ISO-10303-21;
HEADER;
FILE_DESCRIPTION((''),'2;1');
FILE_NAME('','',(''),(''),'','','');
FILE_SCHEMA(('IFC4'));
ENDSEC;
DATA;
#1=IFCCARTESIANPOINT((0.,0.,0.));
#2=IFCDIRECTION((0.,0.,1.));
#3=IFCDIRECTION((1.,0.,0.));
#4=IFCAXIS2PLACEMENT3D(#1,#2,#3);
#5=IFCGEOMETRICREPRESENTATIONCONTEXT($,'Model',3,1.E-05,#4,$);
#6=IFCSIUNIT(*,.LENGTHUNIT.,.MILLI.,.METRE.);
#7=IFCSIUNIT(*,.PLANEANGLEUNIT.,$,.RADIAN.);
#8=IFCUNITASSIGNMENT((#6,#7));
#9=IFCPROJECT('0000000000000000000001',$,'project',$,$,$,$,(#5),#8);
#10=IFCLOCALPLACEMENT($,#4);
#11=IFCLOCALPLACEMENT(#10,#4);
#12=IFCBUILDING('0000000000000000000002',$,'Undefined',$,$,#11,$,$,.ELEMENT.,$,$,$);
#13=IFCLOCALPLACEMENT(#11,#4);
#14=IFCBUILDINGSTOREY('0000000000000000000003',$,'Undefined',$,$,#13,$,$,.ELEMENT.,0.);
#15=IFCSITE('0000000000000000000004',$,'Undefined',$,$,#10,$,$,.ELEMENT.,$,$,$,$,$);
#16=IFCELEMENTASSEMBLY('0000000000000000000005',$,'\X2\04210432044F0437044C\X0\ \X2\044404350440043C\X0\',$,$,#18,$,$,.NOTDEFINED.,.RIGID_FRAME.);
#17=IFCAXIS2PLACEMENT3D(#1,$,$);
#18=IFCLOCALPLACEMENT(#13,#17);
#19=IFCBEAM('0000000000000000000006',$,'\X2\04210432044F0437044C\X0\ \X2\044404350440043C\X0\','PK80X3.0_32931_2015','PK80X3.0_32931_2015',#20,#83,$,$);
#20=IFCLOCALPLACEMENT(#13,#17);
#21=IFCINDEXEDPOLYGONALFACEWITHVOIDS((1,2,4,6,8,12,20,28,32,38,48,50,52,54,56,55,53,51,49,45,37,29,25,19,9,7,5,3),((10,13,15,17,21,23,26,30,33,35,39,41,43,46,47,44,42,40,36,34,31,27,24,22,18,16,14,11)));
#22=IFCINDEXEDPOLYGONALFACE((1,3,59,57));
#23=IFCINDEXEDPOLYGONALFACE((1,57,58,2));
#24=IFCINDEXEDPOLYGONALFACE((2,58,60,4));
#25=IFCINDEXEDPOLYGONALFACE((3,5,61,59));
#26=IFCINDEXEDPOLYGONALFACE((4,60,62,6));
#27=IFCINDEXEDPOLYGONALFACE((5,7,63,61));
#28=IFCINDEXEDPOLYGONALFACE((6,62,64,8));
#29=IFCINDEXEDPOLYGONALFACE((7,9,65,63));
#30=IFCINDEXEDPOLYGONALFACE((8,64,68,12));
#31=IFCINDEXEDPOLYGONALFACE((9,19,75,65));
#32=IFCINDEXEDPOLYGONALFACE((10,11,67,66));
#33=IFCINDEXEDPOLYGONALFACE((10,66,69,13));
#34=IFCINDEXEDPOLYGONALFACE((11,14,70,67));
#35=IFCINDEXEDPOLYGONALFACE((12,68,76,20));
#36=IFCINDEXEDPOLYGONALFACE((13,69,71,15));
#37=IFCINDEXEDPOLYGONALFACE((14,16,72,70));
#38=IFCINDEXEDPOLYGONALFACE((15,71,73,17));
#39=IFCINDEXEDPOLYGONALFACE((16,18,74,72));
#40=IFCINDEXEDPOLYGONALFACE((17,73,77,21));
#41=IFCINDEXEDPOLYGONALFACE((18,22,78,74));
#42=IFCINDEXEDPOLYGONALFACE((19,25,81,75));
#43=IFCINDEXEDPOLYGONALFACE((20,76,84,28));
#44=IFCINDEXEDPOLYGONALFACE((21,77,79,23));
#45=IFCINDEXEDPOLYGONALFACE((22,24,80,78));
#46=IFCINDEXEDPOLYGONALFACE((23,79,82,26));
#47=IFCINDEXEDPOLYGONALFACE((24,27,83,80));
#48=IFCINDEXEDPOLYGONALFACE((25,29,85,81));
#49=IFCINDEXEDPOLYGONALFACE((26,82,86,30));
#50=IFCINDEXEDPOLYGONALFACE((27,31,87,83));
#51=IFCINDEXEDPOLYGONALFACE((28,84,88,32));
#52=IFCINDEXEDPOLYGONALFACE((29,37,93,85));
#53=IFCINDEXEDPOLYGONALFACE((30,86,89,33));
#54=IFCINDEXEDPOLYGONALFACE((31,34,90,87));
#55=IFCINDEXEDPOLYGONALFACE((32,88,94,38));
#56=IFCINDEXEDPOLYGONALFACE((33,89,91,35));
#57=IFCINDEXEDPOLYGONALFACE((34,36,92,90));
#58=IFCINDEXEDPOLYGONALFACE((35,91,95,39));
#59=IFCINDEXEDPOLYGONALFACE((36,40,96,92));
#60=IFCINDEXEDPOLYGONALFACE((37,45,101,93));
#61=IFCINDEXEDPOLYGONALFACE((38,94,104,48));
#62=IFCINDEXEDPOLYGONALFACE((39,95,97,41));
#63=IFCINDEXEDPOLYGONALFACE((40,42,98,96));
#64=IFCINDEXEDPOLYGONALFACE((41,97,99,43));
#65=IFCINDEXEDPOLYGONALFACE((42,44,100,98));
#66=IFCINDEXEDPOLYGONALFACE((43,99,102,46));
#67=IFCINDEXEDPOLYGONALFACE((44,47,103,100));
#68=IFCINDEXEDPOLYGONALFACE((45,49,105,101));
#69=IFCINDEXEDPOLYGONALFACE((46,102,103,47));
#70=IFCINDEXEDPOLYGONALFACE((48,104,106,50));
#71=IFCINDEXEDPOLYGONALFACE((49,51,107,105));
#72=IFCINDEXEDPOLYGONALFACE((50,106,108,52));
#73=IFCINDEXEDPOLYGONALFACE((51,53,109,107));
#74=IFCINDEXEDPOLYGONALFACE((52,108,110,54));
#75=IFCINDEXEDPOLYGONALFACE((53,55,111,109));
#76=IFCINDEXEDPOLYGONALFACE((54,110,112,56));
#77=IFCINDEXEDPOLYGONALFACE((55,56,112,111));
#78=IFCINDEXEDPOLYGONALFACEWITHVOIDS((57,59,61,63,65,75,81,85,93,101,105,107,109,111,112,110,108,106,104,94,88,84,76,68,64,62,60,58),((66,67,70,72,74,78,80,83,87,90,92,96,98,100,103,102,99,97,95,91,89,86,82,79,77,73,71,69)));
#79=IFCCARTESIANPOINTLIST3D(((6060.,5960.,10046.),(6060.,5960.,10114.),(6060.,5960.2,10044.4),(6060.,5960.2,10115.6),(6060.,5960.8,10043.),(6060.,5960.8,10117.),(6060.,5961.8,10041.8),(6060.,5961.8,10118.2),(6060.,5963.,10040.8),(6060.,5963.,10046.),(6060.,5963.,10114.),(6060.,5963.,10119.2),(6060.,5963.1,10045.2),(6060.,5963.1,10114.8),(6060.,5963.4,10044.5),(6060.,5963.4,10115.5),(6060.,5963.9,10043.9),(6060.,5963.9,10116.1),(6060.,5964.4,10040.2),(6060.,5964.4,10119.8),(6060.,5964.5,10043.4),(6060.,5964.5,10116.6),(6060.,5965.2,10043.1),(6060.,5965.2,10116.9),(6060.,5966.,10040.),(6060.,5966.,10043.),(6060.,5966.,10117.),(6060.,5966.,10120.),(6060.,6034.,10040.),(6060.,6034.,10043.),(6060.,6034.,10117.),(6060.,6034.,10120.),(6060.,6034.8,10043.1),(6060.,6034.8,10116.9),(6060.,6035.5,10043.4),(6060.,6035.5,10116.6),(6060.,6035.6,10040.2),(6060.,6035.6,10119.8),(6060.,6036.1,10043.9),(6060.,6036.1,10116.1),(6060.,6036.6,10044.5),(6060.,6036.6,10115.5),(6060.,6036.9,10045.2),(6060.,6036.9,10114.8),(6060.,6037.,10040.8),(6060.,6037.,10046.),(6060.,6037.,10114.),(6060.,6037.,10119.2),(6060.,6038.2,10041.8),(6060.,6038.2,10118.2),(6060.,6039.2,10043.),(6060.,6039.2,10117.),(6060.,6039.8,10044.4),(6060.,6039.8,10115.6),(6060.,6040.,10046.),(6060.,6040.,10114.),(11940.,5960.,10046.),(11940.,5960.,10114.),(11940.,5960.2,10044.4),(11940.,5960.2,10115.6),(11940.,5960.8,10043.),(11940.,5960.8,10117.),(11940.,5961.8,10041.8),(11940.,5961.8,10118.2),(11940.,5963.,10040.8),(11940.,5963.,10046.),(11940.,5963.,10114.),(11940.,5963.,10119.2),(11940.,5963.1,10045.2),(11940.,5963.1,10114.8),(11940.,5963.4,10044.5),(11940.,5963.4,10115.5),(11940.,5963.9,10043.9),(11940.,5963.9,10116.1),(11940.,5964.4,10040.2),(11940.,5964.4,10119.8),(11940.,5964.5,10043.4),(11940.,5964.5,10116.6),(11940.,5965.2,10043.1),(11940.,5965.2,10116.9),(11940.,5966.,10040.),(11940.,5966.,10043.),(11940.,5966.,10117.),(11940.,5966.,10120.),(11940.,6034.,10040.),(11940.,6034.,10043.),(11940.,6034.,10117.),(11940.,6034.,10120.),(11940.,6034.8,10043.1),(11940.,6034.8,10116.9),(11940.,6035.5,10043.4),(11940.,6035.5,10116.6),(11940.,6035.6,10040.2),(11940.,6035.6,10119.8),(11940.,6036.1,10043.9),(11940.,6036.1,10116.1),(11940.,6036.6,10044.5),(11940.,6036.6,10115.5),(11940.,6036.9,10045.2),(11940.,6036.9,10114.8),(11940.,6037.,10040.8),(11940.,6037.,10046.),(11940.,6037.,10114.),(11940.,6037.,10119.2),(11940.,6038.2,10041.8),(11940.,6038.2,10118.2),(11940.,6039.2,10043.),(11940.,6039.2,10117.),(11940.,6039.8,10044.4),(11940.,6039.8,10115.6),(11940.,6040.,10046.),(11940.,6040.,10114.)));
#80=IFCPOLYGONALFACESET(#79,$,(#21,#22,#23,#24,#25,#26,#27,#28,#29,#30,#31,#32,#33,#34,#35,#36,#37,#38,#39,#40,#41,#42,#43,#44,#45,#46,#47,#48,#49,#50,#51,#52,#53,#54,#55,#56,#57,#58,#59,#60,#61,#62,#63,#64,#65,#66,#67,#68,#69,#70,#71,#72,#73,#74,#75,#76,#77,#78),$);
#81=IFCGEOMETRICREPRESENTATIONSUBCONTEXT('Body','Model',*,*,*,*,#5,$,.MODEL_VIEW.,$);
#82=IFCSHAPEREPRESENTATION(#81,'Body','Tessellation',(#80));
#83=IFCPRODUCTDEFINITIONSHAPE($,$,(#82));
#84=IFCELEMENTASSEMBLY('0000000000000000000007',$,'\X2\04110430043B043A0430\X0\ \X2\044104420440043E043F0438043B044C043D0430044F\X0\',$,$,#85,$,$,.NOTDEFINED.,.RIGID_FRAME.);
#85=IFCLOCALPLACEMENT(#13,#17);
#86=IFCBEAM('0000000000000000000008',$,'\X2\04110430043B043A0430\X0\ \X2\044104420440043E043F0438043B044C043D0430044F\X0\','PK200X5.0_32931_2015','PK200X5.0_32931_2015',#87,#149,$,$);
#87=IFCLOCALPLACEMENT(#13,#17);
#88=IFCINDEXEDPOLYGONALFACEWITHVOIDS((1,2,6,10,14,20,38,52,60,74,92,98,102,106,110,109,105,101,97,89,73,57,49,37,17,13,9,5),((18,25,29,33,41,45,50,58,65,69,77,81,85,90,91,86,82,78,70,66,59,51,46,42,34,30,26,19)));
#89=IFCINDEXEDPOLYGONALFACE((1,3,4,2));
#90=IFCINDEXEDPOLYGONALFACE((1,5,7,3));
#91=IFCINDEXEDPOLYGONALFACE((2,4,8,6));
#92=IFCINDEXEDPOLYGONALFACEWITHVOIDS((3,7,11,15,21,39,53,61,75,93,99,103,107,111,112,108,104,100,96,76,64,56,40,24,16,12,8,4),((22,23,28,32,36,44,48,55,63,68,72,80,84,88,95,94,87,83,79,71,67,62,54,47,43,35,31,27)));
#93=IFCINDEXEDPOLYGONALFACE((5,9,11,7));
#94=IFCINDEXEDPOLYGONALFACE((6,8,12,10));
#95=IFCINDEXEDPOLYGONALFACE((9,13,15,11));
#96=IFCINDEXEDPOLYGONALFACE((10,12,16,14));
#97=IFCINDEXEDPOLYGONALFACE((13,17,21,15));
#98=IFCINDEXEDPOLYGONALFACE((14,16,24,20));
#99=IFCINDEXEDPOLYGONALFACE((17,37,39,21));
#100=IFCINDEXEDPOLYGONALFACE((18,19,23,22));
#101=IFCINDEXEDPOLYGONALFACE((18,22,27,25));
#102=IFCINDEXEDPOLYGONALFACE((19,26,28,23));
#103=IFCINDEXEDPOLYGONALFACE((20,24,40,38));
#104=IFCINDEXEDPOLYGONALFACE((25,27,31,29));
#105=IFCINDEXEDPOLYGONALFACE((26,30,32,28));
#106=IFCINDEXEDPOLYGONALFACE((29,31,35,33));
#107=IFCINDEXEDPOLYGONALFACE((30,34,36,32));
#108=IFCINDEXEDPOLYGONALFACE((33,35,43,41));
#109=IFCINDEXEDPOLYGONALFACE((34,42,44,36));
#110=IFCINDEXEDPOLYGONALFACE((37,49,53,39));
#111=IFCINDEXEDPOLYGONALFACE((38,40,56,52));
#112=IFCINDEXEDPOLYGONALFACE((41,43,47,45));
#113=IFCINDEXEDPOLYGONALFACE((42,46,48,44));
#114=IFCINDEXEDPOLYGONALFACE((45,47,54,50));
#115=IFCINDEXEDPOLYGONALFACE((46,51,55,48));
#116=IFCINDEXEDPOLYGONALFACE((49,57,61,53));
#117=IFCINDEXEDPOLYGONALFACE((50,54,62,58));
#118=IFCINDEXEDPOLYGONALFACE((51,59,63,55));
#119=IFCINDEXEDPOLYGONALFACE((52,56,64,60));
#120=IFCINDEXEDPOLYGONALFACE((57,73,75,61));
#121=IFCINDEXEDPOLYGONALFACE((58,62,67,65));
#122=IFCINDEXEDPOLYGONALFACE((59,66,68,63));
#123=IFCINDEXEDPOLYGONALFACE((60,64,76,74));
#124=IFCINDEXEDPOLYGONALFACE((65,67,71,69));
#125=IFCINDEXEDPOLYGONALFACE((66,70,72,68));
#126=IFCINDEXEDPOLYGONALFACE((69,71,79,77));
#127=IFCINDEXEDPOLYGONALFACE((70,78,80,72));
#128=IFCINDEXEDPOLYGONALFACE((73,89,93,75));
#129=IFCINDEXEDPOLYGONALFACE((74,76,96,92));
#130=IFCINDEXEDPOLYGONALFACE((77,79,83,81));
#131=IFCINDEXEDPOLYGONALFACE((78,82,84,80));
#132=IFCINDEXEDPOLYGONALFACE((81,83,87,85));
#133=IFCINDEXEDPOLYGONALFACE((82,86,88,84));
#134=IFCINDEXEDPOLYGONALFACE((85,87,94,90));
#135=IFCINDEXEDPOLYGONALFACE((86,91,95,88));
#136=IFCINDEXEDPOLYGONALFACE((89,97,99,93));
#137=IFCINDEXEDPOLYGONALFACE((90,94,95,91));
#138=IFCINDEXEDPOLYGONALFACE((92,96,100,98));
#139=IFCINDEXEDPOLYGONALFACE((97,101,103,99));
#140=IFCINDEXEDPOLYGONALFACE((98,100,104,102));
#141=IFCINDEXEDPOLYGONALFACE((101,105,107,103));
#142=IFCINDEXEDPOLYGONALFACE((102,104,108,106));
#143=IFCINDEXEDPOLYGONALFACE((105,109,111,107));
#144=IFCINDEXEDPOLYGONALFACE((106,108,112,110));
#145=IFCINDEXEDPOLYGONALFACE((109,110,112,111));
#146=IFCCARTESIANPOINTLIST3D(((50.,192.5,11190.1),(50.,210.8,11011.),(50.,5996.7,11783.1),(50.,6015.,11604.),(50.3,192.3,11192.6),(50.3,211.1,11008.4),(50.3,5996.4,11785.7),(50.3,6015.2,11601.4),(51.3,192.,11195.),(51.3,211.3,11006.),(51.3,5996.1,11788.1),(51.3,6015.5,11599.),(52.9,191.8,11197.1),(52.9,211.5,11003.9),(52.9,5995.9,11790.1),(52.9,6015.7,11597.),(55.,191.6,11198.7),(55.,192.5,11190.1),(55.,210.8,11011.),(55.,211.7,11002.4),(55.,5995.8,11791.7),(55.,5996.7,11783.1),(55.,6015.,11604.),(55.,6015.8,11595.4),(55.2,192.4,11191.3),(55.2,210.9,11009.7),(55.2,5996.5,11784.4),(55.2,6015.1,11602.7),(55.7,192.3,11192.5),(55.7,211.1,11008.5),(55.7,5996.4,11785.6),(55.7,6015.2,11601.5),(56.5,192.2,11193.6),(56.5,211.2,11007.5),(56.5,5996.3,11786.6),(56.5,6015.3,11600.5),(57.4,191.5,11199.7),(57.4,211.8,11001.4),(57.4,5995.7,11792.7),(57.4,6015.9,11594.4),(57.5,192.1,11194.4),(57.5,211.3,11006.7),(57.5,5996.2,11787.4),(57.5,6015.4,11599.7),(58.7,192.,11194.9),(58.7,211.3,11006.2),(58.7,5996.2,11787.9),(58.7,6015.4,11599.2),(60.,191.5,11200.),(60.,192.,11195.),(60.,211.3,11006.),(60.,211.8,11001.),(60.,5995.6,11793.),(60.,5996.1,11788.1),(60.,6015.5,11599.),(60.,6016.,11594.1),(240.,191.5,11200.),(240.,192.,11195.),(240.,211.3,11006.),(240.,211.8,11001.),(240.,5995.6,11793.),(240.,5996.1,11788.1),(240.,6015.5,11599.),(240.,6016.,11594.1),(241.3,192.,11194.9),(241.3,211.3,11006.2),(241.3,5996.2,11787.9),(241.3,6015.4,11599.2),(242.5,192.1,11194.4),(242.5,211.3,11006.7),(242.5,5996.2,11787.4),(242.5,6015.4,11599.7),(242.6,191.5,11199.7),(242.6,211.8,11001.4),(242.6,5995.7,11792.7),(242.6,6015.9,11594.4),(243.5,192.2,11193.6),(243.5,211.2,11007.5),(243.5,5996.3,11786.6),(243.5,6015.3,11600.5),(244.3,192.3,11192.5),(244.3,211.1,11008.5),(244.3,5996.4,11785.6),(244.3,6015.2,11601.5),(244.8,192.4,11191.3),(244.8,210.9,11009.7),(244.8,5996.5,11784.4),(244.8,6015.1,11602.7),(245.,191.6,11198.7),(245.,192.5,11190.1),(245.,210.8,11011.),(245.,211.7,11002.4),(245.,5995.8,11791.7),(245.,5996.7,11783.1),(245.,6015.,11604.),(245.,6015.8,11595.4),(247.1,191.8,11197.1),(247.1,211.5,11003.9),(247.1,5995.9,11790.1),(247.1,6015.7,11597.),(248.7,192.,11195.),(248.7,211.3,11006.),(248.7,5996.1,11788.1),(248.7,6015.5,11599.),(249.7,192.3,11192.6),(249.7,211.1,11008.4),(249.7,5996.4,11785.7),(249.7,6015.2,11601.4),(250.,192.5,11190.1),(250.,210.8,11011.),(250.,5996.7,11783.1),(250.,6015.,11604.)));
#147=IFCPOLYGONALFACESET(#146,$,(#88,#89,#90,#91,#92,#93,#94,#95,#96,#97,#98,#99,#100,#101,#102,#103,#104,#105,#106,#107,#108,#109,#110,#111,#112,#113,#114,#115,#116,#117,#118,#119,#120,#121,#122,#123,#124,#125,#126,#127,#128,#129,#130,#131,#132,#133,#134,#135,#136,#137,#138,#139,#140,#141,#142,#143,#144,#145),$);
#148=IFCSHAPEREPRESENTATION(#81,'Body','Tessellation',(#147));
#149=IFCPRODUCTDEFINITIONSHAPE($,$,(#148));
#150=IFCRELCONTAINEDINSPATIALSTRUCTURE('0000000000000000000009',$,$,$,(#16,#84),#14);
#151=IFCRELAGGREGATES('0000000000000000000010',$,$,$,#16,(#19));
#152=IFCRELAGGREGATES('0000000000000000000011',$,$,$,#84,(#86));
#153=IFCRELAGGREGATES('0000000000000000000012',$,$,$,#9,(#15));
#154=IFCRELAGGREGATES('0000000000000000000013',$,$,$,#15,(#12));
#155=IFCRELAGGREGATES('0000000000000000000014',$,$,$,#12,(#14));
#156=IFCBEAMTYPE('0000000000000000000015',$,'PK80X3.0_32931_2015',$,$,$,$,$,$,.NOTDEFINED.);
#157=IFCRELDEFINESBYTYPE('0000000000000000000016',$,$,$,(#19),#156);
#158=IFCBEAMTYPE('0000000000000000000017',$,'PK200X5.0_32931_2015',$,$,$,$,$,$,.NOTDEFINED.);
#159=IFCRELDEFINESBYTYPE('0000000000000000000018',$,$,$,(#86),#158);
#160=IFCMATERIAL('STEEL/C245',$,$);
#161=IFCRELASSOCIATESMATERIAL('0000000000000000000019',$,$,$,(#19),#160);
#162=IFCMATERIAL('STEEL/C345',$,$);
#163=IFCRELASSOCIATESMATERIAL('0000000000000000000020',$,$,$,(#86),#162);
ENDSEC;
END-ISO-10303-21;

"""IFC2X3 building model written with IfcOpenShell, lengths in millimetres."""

from ifc_helpers import new_model, si_unit, frame, origin_with_axes, origin_2d_with_axis, place, context, subcontext, project, spatial, hollow_rectangle, extrude, material, type_object, element, aggregate, save


model = new_model("IFC2X3")

# Units and contexts
model_context = context("Model", 3, precision=1e-05, world=origin_with_axes())
body_context = subcontext(model_context, "Body", "Model", "MODEL_VIEW")
ifc_project = project(units=[si_unit("LENGTHUNIT", "METRE", prefix="MILLI"), si_unit("PLANEANGLEUNIT", "RADIAN")], contexts=[model_context])

# Site, building, storey
site_placement = place(None, origin_with_axes())
site = spatial("IfcSite", under=ifc_project, at=site_placement, Name="Undefined", CompositionType="ELEMENT")
building_placement = place(site_placement, origin_with_axes())
building = spatial("IfcBuilding", under=site, at=building_placement, Name="Undefined", CompositionType="ELEMENT")
storey_placement = place(building_placement, origin_with_axes())
storey = spatial("IfcBuildingStorey", under=building, at=storey_placement, Name="Undefined", CompositionType="ELEMENT", Elevation=0.0)

# Shared definitions
ifc_material_1 = material(Name="STEEL/C245")

# Element assemblies, beams
assembly_1_placement = place(storey_placement, origin_with_axes())
assembly_1 = element("IfcElementAssembly", 1, at=assembly_1_placement, inside=storey, Name="Связь ферм", AssemblyPlace="NOTDEFINED", PredefinedType="RIGID_FRAME")
beam_type_1 = type_object("IfcBeamType", Name="PK80X3.0_32931_2015", PredefinedType="NOTDEFINED")
beam_1_placement = place(assembly_1_placement, frame((6060.0, 6000.0, 10080.0), z_axis=(0.0, 0.0, 1.0), x_axis=(1.0, 0.0, 0.0)))
beam_1 = element("IfcBeam", 2, at=beam_1_placement, type_object=beam_type_1, material=ifc_material_1, Name="Связь ферм", Description="PK80X3.0_32931_2015", ObjectType="PK80X3.0_32931_2015", context=body_context, shape_type="SweptSolid", body=[
    extrude(hollow_rectangle(XDim=80.0, YDim=80.0, WallThickness=3.0, InnerFilletRadius=3.0, OuterFilletRadius=6.0, at=origin_2d_with_axis()), frame((5880.0, 0.0, 0.0), z_axis=(-1.0, 0.0, 0.0), x_axis=(0.0, -1.0, 0.0)), (0.0, 0.0, 1.0), 5880.0),
])
aggregate(assembly_1, [beam_1])
assembly_2_placement = place(storey_placement, origin_with_axes())
assembly_2 = element("IfcElementAssembly", 3, at=assembly_2_placement, inside=storey, Name="Балка стропильная", AssemblyPlace="NOTDEFINED", PredefinedType="RIGID_FRAME")
ifc_material_2 = material(Name="STEEL/C345")
beam_type_2 = type_object("IfcBeamType", Name="PK200X5.0_32931_2015", PredefinedType="NOTDEFINED")
beam_2_placement = place(assembly_2_placement, frame((150.0, 201.7, 11100.5), z_axis=(0.0, -0.101645, 0.994821), x_axis=(0.0, 0.994821, 0.101645)))
beam_2 = element("IfcBeam", 4, at=beam_2_placement, type_object=beam_type_2, material=ifc_material_2, Name="Балка стропильная", Description="PK200X5.0_32931_2015", ObjectType="PK200X5.0_32931_2015", context=body_context, shape_type="SweptSolid", body=[
    extrude(hollow_rectangle(XDim=200.0, YDim=200.0, WallThickness=5.0, InnerFilletRadius=5.0, OuterFilletRadius=10.0, at=origin_2d_with_axis()), frame((5834.4, 0.0, 0.0), z_axis=(-1.0, 0.0, 0.0), x_axis=(0.0, -1.0, 0.0)), (0.0, 0.0, 1.0), 5834.4),
])
aggregate(assembly_2, [beam_2])

save(model, "model.ifc")
